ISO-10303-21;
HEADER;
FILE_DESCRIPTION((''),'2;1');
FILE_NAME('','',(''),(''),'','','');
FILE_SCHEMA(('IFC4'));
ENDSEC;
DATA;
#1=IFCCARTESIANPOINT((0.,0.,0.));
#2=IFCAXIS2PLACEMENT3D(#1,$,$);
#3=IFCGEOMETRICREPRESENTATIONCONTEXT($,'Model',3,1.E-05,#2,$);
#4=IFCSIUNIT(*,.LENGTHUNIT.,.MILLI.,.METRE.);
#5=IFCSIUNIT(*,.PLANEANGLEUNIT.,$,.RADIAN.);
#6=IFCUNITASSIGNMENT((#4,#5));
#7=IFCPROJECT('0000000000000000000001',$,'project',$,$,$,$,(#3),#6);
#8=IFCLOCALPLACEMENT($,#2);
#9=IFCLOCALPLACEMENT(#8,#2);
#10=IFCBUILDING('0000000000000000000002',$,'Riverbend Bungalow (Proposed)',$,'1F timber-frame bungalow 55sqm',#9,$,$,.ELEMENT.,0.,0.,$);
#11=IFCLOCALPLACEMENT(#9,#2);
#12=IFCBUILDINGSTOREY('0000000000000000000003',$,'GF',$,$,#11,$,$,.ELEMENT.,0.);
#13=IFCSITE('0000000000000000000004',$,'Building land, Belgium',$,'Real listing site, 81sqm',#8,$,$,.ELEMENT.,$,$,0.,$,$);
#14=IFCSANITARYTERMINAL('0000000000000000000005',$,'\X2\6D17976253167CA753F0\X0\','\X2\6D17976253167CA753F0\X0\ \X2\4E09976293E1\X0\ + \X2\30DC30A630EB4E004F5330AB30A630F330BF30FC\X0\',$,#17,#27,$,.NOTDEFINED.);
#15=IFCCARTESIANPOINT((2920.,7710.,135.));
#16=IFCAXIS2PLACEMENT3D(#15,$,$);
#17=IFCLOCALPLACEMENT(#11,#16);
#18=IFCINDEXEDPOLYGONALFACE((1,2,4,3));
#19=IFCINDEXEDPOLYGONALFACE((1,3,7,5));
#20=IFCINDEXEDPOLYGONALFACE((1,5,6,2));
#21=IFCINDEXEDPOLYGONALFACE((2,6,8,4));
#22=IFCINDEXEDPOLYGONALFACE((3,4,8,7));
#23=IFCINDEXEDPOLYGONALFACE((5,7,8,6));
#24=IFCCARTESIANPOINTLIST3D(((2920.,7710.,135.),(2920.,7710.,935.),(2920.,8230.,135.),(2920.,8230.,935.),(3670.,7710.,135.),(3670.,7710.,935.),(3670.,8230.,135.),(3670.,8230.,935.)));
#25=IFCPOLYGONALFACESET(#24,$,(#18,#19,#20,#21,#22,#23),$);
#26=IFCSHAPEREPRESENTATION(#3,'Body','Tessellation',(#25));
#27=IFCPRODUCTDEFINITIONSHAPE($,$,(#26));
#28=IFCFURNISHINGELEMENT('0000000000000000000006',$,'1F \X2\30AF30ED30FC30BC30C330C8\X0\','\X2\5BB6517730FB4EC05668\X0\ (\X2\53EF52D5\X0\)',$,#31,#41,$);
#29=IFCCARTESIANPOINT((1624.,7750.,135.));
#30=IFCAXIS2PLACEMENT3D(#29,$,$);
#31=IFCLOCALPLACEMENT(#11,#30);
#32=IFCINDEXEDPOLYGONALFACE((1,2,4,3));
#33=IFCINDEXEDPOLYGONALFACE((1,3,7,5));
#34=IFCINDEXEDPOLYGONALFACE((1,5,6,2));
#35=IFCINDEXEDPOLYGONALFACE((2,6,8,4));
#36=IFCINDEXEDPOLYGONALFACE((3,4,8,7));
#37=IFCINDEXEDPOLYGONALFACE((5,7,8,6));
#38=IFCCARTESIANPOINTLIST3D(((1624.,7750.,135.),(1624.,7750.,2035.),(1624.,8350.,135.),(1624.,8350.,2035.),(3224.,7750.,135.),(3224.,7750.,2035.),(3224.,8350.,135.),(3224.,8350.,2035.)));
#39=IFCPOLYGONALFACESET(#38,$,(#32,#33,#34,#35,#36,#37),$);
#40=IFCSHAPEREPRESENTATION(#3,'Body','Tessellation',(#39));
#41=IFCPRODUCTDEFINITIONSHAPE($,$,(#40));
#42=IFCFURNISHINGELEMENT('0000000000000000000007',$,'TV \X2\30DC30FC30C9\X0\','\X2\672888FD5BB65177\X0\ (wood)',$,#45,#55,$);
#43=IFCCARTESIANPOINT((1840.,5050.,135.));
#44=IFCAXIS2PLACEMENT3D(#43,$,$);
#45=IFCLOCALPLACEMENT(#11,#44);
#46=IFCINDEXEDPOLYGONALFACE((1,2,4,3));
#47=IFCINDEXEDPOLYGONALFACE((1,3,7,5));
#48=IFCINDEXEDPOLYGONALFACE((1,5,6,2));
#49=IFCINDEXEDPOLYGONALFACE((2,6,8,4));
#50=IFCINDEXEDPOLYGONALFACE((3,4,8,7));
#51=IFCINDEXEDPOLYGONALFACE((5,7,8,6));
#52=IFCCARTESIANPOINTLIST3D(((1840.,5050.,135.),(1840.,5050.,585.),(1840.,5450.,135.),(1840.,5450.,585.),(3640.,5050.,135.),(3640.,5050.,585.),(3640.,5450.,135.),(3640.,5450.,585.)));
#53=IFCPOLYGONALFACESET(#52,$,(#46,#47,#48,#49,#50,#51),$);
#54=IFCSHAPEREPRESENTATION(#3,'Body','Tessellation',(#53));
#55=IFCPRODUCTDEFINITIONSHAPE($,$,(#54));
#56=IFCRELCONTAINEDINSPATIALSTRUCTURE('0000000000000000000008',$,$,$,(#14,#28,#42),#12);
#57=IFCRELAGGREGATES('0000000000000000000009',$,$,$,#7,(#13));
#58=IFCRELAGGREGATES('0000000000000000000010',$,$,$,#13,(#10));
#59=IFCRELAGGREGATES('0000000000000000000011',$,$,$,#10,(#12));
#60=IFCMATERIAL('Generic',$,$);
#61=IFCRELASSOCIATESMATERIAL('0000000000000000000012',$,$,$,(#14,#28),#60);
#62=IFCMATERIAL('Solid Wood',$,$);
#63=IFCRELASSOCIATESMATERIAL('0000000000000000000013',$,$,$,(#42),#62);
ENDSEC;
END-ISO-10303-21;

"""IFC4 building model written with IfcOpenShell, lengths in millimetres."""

from ifc_helpers import new_model, si_unit, frame, frame_2d, origin, place, context, project, spatial, rectangle, extrude, material, element, save


model = new_model("IFC4")

# Units and contexts
model_context = context("Model", 3, precision=1e-05, world=origin())
ifc_project = project(units=[si_unit("LENGTHUNIT", "METRE", prefix="MILLI"), si_unit("PLANEANGLEUNIT", "RADIAN")], contexts=[model_context])

# Site, building, storey
site_placement = place(None, origin())
site = spatial("IfcSite", under=ifc_project, at=site_placement, Name="Building land, Belgium", ObjectType="Real listing site, 81sqm", CompositionType="ELEMENT", RefElevation=0.0)
building_placement = place(site_placement, origin())
building = spatial("IfcBuilding", under=site, at=building_placement, Name="Riverbend Bungalow (Proposed)", ObjectType="1F timber-frame bungalow 55sqm", CompositionType="ELEMENT", ElevationOfRefHeight=0.0, ElevationOfTerrain=0.0)
storey_placement = place(building_placement, origin())
storey = spatial("IfcBuildingStorey", under=building, at=storey_placement, Name="GF", CompositionType="ELEMENT", Elevation=0.0)

# Shared definitions
ifc_material_1 = material(Name="Solid Wood")

# Shared definitions
ifc_material_2 = material(Name="Generic")

# Sanitary terminal
sanitary_terminal_1_placement = place(storey_placement, frame((2920.0, 7710.0, 135.0)))
element("IfcSanitaryTerminal", 1, at=sanitary_terminal_1_placement, inside=storey, material=ifc_material_2, Name="洗面化粧台", Description="洗面化粧台 三面鏡 + ボウル一体カウンター", PredefinedType="NOTDEFINED", context=model_context, shape_type="SweptSolid", body=[
    extrude(rectangle(XDim=750.0, YDim=520.0, at=frame_2d((375.0, 260.0))), frame((2920.0, 7710.0, 135.0)), (0.0, 0.0, 1.0), 800.0),
])

# Furnishing elements
furnishing_1_placement = place(storey_placement, frame((1624.0, 7750.0, 135.0)))
element("IfcFurnishingElement", 2, at=furnishing_1_placement, inside=storey, material=ifc_material_2, Name="1F クローゼット", Description="家具・什器 (可動)", context=model_context, shape_type="SweptSolid", body=[
    extrude(rectangle(XDim=1600.0, YDim=600.0, at=frame_2d((800.0, 300.0))), frame((1624.0, 7750.0, 135.0)), (0.0, 0.0, 1.0), 1900.0),
])
furnishing_2_placement = place(storey_placement, frame((1840.0, 5050.0, 135.0)))
element("IfcFurnishingElement", 3, at=furnishing_2_placement, inside=storey, material=ifc_material_1, Name="TV ボード", Description="木製家具 (wood)", context=model_context, shape_type="SweptSolid", body=[
    extrude(rectangle(XDim=1800.0, YDim=400.0, at=frame_2d((900.0, 200.0))), frame((1840.0, 5050.0, 135.0)), (0.0, 0.0, 1.0), 450.0),
])

save(model, "model.ifc")
